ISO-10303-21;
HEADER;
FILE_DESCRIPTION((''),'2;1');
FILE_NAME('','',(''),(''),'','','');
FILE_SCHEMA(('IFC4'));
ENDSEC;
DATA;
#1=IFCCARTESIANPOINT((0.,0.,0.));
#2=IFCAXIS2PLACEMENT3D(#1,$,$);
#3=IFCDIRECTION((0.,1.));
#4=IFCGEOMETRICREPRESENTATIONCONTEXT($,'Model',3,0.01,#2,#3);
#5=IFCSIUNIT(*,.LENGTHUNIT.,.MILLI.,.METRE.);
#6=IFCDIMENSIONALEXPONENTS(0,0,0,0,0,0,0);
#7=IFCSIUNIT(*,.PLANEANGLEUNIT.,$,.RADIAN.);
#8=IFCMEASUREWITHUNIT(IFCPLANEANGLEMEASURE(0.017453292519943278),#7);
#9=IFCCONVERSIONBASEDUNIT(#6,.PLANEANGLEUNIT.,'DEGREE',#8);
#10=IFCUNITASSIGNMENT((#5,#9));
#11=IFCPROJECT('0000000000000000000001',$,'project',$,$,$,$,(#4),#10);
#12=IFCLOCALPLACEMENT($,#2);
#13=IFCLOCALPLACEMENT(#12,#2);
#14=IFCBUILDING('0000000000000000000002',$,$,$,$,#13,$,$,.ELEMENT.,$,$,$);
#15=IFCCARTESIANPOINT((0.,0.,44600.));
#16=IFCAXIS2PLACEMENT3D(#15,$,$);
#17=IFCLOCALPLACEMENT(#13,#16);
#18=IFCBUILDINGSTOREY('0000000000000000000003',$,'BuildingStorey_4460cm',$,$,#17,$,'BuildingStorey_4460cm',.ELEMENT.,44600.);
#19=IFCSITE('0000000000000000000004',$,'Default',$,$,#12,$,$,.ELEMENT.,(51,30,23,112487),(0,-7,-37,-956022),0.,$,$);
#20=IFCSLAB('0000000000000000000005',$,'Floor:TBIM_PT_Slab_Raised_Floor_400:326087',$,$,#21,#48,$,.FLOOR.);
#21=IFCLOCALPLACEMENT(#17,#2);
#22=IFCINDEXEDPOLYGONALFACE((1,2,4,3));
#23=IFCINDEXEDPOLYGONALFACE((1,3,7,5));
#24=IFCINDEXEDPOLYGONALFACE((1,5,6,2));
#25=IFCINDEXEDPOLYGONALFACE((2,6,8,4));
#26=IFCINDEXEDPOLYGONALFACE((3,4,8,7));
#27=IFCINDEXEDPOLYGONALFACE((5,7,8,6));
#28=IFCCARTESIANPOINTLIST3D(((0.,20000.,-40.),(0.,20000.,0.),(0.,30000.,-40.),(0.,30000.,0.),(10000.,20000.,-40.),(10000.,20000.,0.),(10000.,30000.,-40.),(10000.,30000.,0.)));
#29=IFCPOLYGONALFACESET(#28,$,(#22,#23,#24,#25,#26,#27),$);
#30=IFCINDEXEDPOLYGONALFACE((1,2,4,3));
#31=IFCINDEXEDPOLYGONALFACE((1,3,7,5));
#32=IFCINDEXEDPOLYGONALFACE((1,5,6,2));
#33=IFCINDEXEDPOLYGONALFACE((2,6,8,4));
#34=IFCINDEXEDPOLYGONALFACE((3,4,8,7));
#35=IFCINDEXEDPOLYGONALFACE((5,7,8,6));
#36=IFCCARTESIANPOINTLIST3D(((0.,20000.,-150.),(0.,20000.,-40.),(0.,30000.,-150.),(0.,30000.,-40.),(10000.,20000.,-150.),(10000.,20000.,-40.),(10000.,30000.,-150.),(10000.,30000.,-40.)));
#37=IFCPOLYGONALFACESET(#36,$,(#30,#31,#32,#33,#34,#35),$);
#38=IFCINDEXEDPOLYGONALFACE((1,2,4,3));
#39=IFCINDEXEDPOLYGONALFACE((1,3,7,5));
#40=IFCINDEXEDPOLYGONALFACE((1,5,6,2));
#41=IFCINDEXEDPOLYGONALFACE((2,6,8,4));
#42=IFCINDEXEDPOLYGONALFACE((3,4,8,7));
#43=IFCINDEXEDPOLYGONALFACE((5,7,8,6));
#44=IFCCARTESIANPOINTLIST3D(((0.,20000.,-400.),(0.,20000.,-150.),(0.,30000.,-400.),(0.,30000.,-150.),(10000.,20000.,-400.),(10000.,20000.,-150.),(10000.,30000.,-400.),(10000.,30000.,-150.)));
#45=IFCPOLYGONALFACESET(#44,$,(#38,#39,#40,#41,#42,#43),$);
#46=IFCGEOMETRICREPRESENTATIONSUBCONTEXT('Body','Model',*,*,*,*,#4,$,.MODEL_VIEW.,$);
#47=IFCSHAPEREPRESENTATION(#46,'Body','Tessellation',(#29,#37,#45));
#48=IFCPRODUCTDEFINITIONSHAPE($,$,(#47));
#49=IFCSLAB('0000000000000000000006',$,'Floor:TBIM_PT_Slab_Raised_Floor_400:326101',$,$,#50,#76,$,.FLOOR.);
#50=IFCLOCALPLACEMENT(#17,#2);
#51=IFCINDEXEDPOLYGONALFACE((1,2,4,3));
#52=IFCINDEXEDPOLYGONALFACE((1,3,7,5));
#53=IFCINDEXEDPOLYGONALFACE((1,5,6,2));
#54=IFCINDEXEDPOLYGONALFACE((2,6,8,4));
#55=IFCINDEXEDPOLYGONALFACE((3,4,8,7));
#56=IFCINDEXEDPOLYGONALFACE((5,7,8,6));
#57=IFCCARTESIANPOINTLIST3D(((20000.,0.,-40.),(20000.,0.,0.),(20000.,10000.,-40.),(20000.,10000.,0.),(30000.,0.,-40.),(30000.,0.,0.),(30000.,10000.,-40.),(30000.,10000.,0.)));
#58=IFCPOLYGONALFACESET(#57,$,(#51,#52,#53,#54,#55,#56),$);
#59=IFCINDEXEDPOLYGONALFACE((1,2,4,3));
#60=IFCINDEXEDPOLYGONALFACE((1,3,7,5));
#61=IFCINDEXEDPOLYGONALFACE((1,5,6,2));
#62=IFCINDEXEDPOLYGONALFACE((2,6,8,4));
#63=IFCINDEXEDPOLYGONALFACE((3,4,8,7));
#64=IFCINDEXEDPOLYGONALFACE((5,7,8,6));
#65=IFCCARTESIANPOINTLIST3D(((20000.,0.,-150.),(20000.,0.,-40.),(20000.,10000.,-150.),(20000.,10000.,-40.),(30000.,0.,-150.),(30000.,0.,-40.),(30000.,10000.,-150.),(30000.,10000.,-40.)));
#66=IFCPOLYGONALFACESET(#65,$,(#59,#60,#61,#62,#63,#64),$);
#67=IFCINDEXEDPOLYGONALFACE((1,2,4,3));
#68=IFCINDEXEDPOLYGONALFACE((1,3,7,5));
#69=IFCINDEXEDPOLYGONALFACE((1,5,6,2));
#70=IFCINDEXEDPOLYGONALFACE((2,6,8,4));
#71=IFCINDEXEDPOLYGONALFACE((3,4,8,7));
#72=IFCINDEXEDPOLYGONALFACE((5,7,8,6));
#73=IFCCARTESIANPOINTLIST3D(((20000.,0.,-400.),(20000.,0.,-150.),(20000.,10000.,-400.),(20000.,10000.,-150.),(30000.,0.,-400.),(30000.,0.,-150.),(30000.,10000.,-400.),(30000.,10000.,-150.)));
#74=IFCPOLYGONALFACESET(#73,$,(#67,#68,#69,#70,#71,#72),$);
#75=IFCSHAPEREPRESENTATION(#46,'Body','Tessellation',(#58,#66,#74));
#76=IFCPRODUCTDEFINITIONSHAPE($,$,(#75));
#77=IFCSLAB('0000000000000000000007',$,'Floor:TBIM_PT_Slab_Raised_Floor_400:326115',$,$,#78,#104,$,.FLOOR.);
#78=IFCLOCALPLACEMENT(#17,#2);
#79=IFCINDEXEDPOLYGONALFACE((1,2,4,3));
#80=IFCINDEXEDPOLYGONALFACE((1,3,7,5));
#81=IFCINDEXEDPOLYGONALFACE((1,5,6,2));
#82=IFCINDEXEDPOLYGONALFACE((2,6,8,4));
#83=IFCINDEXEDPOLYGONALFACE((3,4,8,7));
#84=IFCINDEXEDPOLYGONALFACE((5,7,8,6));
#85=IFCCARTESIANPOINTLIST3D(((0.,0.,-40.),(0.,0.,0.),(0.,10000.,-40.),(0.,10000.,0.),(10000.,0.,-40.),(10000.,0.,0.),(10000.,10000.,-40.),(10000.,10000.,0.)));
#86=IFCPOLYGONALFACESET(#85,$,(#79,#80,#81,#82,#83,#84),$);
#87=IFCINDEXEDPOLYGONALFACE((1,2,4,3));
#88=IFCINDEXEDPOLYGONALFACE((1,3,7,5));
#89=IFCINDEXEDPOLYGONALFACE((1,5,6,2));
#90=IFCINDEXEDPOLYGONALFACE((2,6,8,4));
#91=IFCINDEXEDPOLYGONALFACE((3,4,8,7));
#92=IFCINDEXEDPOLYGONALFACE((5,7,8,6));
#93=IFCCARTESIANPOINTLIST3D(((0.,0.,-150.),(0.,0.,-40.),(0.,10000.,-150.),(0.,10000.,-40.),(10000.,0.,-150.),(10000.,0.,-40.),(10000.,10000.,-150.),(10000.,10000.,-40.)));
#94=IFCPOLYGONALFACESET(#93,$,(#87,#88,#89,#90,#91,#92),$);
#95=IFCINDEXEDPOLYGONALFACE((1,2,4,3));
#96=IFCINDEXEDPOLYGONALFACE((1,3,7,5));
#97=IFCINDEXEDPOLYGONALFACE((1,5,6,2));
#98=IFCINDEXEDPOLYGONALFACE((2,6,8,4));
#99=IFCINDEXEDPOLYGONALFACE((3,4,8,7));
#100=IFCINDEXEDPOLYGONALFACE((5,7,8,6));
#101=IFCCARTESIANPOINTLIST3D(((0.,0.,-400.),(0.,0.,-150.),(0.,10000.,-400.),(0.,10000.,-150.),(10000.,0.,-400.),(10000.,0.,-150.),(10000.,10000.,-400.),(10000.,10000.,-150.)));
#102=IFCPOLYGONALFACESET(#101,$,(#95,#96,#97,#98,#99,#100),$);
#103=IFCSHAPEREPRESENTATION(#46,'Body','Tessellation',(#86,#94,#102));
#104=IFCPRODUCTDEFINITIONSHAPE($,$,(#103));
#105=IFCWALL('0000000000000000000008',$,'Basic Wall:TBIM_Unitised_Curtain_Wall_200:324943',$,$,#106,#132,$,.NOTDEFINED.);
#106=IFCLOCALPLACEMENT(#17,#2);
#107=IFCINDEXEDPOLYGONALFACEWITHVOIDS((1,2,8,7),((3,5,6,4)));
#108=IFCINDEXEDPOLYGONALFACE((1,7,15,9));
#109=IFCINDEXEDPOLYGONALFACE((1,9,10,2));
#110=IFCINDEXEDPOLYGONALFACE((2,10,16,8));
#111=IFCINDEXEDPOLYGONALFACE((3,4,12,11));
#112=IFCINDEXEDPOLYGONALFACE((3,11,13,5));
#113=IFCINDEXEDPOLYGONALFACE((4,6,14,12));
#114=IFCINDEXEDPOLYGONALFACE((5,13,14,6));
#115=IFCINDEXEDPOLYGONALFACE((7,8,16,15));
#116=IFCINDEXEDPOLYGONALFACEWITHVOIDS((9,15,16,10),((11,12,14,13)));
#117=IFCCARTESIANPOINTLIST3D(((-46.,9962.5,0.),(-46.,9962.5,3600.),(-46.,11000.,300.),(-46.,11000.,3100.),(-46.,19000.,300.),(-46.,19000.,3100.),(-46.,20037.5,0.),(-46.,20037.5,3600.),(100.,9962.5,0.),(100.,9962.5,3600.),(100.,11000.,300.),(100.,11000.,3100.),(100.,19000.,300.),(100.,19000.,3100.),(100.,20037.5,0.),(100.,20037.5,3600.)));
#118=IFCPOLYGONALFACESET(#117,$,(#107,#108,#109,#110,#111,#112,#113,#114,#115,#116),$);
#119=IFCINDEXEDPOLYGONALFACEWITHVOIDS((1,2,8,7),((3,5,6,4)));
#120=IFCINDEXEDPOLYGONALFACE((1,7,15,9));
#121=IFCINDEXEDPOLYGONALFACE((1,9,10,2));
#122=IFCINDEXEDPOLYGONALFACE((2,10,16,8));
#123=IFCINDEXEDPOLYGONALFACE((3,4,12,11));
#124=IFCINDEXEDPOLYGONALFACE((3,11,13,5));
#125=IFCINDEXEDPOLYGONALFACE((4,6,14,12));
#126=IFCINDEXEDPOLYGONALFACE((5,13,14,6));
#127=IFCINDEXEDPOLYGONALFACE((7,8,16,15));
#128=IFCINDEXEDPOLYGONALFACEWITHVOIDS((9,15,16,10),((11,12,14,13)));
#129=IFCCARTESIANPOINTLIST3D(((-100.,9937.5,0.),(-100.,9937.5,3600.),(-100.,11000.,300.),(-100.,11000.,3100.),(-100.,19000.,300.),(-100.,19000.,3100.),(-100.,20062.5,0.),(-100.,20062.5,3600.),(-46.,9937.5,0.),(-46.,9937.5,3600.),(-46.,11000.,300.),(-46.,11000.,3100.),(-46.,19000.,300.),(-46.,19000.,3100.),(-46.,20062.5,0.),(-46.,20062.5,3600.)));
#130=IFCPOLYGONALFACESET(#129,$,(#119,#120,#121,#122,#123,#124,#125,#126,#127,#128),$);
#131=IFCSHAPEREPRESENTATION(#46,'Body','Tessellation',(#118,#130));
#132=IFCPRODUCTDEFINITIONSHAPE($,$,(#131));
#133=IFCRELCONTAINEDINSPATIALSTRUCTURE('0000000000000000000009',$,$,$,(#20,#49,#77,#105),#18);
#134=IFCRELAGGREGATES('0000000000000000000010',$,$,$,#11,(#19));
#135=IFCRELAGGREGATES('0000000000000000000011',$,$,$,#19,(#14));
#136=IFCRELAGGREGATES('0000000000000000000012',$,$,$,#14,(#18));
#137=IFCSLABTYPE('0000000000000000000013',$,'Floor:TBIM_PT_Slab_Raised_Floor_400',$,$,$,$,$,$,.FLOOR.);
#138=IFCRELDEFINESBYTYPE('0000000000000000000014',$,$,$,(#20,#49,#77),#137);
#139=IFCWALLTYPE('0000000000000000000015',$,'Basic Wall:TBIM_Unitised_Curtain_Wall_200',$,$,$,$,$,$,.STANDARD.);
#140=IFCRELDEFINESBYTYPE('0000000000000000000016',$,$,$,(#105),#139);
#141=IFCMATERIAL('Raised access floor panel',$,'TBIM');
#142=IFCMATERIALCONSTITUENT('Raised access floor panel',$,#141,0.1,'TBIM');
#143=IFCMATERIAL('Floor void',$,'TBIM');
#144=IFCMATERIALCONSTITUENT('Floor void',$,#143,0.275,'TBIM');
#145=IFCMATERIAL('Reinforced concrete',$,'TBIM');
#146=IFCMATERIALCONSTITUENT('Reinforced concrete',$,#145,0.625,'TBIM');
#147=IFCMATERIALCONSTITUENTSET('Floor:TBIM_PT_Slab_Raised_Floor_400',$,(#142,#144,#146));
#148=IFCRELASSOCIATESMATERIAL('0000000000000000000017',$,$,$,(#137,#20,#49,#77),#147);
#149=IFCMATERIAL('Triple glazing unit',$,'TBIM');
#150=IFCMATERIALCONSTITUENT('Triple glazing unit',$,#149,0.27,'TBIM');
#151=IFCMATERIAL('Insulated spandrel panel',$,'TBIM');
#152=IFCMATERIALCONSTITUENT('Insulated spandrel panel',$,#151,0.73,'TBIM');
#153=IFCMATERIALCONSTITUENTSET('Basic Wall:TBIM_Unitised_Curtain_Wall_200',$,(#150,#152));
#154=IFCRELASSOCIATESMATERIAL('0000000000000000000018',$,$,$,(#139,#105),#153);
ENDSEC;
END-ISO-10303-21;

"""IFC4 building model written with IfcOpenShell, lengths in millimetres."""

from ifc_helpers import new_model, entity, si_unit, converted_unit, direction, frame, origin, place, context, subcontext, project, spatial, indexed_curve, outline, extrude, material, constituent, constituent_set, type_object, element, save


model = new_model("IFC4")

# Units and contexts
model_context = context("Model", 3, precision=0.01, world=origin(), true_north=direction((0.0, 1.0)))
body_context = subcontext(model_context, "Body", "Model", "MODEL_VIEW")
ifc_project = project(units=[si_unit("LENGTHUNIT", "METRE", prefix="MILLI"), converted_unit("PLANEANGLEUNIT", "DEGREE", entity("IfcPlaneAngleMeasure", 0.017453292519943278), si_unit("PLANEANGLEUNIT", "RADIAN"), dimensions=[0, 0, 0, 0, 0, 0, 0])], contexts=[model_context])

# Site, building, storey
site_placement = place(None, origin())
site = spatial("IfcSite", under=ifc_project, at=site_placement, Name="Default", CompositionType="ELEMENT", RefLatitude=(51, 30, 23, 112487), RefLongitude=(0, -7, -37, -956022), RefElevation=0.0)
building_placement = place(site_placement, origin())
building = spatial("IfcBuilding", under=site, at=building_placement, CompositionType="ELEMENT")
storey_placement = place(building_placement, frame((0.0, 0.0, 44600.0)))
storey = spatial("IfcBuildingStorey", under=building, at=storey_placement, Name="BuildingStorey_4460cm", LongName="BuildingStorey_4460cm", CompositionType="ELEMENT", Elevation=44600.0)

# Slabs
ifc_material_1 = material(Name="Raised access floor panel", Category="TBIM")
ifc_constituent_1 = constituent(ifc_material_1, Name="Raised access floor panel", Category="TBIM", fraction=0.1)
ifc_material_2 = material(Name="Floor void", Category="TBIM")
ifc_constituent_2 = constituent(ifc_material_2, Name="Floor void", Category="TBIM", fraction=0.275)
ifc_material_3 = material(Name="Reinforced concrete", Category="TBIM")
ifc_constituent_3 = constituent(ifc_material_3, Name="Reinforced concrete", Category="TBIM", fraction=0.625)
ifc_constituent_set_1 = constituent_set(constituents=[ifc_constituent_1, ifc_constituent_2, ifc_constituent_3], Name="Floor:TBIM_PT_Slab_Raised_Floor_400")
slab_type = type_object("IfcSlabType", Name="Floor:TBIM_PT_Slab_Raised_Floor_400", PredefinedType="FLOOR", material=ifc_constituent_set_1)
slab_1_placement = place(storey_placement, origin())
element("IfcSlab", 1, at=slab_1_placement, inside=storey, type_object=slab_type, material=ifc_constituent_set_1, Name="Floor:TBIM_PT_Slab_Raised_Floor_400:326087", PredefinedType="FLOOR", context=body_context, shape_type="SweptSolid", body=[
    extrude(outline(indexed_curve([(-5000.0, -5000.0), (5000.0, -5000.0), (5000.0, 5000.0), (-5000.0, 5000.0), (-5000.0, -5000.0)], self_intersect=False)), frame((5000.0, 25000.0, -40.0), z_axis=(0.0, 0.0, 1.0), x_axis=(-1.0, 0.0, 0.0)), (0.0, 0.0, 1.0), 40.0),
    extrude(outline(indexed_curve([(-5000.0, -5000.0), (5000.0, -5000.0), (5000.0, 5000.0), (-5000.0, 5000.0), (-5000.0, -5000.0)], self_intersect=False)), frame((5000.0, 25000.0, -150.0), z_axis=(0.0, 0.0, 1.0), x_axis=(-1.0, 0.0, 0.0)), (0.0, 0.0, 1.0), 110.0),
    extrude(outline(indexed_curve([(-5000.0, -5000.0), (5000.0, -5000.0), (5000.0, 5000.0), (-5000.0, 5000.0), (-5000.0, -5000.0)], self_intersect=False)), frame((5000.0, 25000.0, -400.0), z_axis=(0.0, 0.0, 1.0), x_axis=(-1.0, 0.0, 0.0)), (0.0, 0.0, 1.0), 250.0),
])
slab_2_placement = place(storey_placement, origin())
element("IfcSlab", 2, at=slab_2_placement, inside=storey, type_object=slab_type, material=ifc_constituent_set_1, Name="Floor:TBIM_PT_Slab_Raised_Floor_400:326101", PredefinedType="FLOOR", context=body_context, shape_type="SweptSolid", body=[
    extrude(outline(indexed_curve([(-5000.0, -5000.0), (5000.0, -5000.0), (5000.0, 5000.0), (-5000.0, 5000.0), (-5000.0, -5000.0)], self_intersect=False)), frame((25000.0, 5000.0, -40.0), z_axis=(0.0, 0.0, 1.0), x_axis=(-1.0, 0.0, 0.0)), (0.0, 0.0, 1.0), 40.0),
    extrude(outline(indexed_curve([(-5000.0, -5000.0), (5000.0, -5000.0), (5000.0, 5000.0), (-5000.0, 5000.0), (-5000.0, -5000.0)], self_intersect=False)), frame((25000.0, 5000.0, -150.0), z_axis=(0.0, 0.0, 1.0), x_axis=(-1.0, 0.0, 0.0)), (0.0, 0.0, 1.0), 110.0),
    extrude(outline(indexed_curve([(-5000.0, -5000.0), (5000.0, -5000.0), (5000.0, 5000.0), (-5000.0, 5000.0), (-5000.0, -5000.0)], self_intersect=False)), frame((25000.0, 5000.0, -400.0), z_axis=(0.0, 0.0, 1.0), x_axis=(-1.0, 0.0, 0.0)), (0.0, 0.0, 1.0), 250.0),
])
slab_3_placement = place(storey_placement, origin())
element("IfcSlab", 3, at=slab_3_placement, inside=storey, type_object=slab_type, material=ifc_constituent_set_1, Name="Floor:TBIM_PT_Slab_Raised_Floor_400:326115", PredefinedType="FLOOR", context=body_context, shape_type="SweptSolid", body=[
    extrude(outline(indexed_curve([(-5000.0, -5000.0), (5000.0, -5000.0), (5000.0, 5000.0), (-5000.0, 5000.0), (-5000.0, -5000.0)], self_intersect=False)), frame((5000.0, 5000.0, -40.0), z_axis=(0.0, 0.0, 1.0), x_axis=(-1.0, 0.0, 0.0)), (0.0, 0.0, 1.0), 40.0),
    extrude(outline(indexed_curve([(-5000.0, -5000.0), (5000.0, -5000.0), (5000.0, 5000.0), (-5000.0, 5000.0), (-5000.0, -5000.0)], self_intersect=False)), frame((5000.0, 5000.0, -150.0), z_axis=(0.0, 0.0, 1.0), x_axis=(-1.0, 0.0, 0.0)), (0.0, 0.0, 1.0), 110.0),
    extrude(outline(indexed_curve([(-5000.0, -5000.0), (5000.0, -5000.0), (5000.0, 5000.0), (-5000.0, 5000.0), (-5000.0, -5000.0)], self_intersect=False)), frame((5000.0, 5000.0, -400.0), z_axis=(0.0, 0.0, 1.0), x_axis=(-1.0, 0.0, 0.0)), (0.0, 0.0, 1.0), 250.0),
])

# Wall, opening
ifc_material_4 = material(Name="Triple glazing unit", Category="TBIM")
ifc_constituent_4 = constituent(ifc_material_4, Name="Triple glazing unit", Category="TBIM", fraction=0.27)
ifc_material_5 = material(Name="Insulated spandrel panel", Category="TBIM")
ifc_constituent_5 = constituent(ifc_material_5, Name="Insulated spandrel panel", Category="TBIM", fraction=0.73)
ifc_constituent_set_2 = constituent_set(constituents=[ifc_constituent_4, ifc_constituent_5], Name="Basic Wall:TBIM_Unitised_Curtain_Wall_200")
wall_type = type_object("IfcWallType", Name="Basic Wall:TBIM_Unitised_Curtain_Wall_200", PredefinedType="STANDARD", material=ifc_constituent_set_2)
wall_1_placement = place(storey_placement, frame((0.0, 9937.5, 0.0), z_axis=(0.0, 0.0, 1.0), x_axis=(0.0, 1.0, 0.0)))
wall_1 = element("IfcWall", 4, at=wall_1_placement, inside=storey, type_object=wall_type, material=ifc_constituent_set_2, Name="Basic Wall:TBIM_Unitised_Curtain_Wall_200:324943", PredefinedType="NOTDEFINED", context=body_context, shape_type="SweptSolid", body=[
    extrude(outline(indexed_curve([(-1800.0, -5037.5), (1800.0, -5037.5), (1800.0, 5037.5), (-1800.0, 5037.5), (-1800.0, -5037.5)], self_intersect=False), holes=[indexed_curve([(1300.0, 4000.0), (1300.0, -4000.0), (-1500.0, -4000.0), (-1500.0, 4000.0), (1300.0, 4000.0)], self_intersect=False)]), frame((5062.5, 46.0, 1800.0), z_axis=(0.0, -1.0, 0.0), x_axis=(0.0, 0.0, 1.0)), (0.0, 0.0, 1.0), 146.0),
    extrude(outline(indexed_curve([(-5062.5, -1800.0), (5062.5, -1800.0), (5062.5, 1800.0), (-5062.5, 1800.0), (-5062.5, -1800.0)], self_intersect=False), holes=[indexed_curve([(-4000.0, 1300.0), (4000.0, 1300.0), (4000.0, -1500.0), (-4000.0, -1500.0), (-4000.0, 1300.0)], self_intersect=False)]), frame((5062.5, 100.0, 1800.0), z_axis=(0.0, -1.0, 0.0), x_axis=(1.0, 0.0, 0.0)), (0.0, 0.0, 1.0), 54.0),
])
opening_1_placement = place(wall_1_placement, frame((1062.5, -100.0, 300.0)))
element("IfcOpeningElement", 5, at=opening_1_placement, cuts=wall_1, PredefinedType="OPENING", context=body_context, shape_type="SweptSolid", body=[
    extrude(outline(indexed_curve([(2800.0, 0.0), (2800.0, 8000.0), (0.0, 8000.0), (0.0, 0.0), (2800.0, 0.0)], self_intersect=False)), frame((0.0, 0.0, 0.0), z_axis=(0.0, 1.0, 0.0), x_axis=(0.0, 0.0, 1.0)), (0.0, 0.0, 1.0), 200.0),
])

save(model, "model.ifc")
